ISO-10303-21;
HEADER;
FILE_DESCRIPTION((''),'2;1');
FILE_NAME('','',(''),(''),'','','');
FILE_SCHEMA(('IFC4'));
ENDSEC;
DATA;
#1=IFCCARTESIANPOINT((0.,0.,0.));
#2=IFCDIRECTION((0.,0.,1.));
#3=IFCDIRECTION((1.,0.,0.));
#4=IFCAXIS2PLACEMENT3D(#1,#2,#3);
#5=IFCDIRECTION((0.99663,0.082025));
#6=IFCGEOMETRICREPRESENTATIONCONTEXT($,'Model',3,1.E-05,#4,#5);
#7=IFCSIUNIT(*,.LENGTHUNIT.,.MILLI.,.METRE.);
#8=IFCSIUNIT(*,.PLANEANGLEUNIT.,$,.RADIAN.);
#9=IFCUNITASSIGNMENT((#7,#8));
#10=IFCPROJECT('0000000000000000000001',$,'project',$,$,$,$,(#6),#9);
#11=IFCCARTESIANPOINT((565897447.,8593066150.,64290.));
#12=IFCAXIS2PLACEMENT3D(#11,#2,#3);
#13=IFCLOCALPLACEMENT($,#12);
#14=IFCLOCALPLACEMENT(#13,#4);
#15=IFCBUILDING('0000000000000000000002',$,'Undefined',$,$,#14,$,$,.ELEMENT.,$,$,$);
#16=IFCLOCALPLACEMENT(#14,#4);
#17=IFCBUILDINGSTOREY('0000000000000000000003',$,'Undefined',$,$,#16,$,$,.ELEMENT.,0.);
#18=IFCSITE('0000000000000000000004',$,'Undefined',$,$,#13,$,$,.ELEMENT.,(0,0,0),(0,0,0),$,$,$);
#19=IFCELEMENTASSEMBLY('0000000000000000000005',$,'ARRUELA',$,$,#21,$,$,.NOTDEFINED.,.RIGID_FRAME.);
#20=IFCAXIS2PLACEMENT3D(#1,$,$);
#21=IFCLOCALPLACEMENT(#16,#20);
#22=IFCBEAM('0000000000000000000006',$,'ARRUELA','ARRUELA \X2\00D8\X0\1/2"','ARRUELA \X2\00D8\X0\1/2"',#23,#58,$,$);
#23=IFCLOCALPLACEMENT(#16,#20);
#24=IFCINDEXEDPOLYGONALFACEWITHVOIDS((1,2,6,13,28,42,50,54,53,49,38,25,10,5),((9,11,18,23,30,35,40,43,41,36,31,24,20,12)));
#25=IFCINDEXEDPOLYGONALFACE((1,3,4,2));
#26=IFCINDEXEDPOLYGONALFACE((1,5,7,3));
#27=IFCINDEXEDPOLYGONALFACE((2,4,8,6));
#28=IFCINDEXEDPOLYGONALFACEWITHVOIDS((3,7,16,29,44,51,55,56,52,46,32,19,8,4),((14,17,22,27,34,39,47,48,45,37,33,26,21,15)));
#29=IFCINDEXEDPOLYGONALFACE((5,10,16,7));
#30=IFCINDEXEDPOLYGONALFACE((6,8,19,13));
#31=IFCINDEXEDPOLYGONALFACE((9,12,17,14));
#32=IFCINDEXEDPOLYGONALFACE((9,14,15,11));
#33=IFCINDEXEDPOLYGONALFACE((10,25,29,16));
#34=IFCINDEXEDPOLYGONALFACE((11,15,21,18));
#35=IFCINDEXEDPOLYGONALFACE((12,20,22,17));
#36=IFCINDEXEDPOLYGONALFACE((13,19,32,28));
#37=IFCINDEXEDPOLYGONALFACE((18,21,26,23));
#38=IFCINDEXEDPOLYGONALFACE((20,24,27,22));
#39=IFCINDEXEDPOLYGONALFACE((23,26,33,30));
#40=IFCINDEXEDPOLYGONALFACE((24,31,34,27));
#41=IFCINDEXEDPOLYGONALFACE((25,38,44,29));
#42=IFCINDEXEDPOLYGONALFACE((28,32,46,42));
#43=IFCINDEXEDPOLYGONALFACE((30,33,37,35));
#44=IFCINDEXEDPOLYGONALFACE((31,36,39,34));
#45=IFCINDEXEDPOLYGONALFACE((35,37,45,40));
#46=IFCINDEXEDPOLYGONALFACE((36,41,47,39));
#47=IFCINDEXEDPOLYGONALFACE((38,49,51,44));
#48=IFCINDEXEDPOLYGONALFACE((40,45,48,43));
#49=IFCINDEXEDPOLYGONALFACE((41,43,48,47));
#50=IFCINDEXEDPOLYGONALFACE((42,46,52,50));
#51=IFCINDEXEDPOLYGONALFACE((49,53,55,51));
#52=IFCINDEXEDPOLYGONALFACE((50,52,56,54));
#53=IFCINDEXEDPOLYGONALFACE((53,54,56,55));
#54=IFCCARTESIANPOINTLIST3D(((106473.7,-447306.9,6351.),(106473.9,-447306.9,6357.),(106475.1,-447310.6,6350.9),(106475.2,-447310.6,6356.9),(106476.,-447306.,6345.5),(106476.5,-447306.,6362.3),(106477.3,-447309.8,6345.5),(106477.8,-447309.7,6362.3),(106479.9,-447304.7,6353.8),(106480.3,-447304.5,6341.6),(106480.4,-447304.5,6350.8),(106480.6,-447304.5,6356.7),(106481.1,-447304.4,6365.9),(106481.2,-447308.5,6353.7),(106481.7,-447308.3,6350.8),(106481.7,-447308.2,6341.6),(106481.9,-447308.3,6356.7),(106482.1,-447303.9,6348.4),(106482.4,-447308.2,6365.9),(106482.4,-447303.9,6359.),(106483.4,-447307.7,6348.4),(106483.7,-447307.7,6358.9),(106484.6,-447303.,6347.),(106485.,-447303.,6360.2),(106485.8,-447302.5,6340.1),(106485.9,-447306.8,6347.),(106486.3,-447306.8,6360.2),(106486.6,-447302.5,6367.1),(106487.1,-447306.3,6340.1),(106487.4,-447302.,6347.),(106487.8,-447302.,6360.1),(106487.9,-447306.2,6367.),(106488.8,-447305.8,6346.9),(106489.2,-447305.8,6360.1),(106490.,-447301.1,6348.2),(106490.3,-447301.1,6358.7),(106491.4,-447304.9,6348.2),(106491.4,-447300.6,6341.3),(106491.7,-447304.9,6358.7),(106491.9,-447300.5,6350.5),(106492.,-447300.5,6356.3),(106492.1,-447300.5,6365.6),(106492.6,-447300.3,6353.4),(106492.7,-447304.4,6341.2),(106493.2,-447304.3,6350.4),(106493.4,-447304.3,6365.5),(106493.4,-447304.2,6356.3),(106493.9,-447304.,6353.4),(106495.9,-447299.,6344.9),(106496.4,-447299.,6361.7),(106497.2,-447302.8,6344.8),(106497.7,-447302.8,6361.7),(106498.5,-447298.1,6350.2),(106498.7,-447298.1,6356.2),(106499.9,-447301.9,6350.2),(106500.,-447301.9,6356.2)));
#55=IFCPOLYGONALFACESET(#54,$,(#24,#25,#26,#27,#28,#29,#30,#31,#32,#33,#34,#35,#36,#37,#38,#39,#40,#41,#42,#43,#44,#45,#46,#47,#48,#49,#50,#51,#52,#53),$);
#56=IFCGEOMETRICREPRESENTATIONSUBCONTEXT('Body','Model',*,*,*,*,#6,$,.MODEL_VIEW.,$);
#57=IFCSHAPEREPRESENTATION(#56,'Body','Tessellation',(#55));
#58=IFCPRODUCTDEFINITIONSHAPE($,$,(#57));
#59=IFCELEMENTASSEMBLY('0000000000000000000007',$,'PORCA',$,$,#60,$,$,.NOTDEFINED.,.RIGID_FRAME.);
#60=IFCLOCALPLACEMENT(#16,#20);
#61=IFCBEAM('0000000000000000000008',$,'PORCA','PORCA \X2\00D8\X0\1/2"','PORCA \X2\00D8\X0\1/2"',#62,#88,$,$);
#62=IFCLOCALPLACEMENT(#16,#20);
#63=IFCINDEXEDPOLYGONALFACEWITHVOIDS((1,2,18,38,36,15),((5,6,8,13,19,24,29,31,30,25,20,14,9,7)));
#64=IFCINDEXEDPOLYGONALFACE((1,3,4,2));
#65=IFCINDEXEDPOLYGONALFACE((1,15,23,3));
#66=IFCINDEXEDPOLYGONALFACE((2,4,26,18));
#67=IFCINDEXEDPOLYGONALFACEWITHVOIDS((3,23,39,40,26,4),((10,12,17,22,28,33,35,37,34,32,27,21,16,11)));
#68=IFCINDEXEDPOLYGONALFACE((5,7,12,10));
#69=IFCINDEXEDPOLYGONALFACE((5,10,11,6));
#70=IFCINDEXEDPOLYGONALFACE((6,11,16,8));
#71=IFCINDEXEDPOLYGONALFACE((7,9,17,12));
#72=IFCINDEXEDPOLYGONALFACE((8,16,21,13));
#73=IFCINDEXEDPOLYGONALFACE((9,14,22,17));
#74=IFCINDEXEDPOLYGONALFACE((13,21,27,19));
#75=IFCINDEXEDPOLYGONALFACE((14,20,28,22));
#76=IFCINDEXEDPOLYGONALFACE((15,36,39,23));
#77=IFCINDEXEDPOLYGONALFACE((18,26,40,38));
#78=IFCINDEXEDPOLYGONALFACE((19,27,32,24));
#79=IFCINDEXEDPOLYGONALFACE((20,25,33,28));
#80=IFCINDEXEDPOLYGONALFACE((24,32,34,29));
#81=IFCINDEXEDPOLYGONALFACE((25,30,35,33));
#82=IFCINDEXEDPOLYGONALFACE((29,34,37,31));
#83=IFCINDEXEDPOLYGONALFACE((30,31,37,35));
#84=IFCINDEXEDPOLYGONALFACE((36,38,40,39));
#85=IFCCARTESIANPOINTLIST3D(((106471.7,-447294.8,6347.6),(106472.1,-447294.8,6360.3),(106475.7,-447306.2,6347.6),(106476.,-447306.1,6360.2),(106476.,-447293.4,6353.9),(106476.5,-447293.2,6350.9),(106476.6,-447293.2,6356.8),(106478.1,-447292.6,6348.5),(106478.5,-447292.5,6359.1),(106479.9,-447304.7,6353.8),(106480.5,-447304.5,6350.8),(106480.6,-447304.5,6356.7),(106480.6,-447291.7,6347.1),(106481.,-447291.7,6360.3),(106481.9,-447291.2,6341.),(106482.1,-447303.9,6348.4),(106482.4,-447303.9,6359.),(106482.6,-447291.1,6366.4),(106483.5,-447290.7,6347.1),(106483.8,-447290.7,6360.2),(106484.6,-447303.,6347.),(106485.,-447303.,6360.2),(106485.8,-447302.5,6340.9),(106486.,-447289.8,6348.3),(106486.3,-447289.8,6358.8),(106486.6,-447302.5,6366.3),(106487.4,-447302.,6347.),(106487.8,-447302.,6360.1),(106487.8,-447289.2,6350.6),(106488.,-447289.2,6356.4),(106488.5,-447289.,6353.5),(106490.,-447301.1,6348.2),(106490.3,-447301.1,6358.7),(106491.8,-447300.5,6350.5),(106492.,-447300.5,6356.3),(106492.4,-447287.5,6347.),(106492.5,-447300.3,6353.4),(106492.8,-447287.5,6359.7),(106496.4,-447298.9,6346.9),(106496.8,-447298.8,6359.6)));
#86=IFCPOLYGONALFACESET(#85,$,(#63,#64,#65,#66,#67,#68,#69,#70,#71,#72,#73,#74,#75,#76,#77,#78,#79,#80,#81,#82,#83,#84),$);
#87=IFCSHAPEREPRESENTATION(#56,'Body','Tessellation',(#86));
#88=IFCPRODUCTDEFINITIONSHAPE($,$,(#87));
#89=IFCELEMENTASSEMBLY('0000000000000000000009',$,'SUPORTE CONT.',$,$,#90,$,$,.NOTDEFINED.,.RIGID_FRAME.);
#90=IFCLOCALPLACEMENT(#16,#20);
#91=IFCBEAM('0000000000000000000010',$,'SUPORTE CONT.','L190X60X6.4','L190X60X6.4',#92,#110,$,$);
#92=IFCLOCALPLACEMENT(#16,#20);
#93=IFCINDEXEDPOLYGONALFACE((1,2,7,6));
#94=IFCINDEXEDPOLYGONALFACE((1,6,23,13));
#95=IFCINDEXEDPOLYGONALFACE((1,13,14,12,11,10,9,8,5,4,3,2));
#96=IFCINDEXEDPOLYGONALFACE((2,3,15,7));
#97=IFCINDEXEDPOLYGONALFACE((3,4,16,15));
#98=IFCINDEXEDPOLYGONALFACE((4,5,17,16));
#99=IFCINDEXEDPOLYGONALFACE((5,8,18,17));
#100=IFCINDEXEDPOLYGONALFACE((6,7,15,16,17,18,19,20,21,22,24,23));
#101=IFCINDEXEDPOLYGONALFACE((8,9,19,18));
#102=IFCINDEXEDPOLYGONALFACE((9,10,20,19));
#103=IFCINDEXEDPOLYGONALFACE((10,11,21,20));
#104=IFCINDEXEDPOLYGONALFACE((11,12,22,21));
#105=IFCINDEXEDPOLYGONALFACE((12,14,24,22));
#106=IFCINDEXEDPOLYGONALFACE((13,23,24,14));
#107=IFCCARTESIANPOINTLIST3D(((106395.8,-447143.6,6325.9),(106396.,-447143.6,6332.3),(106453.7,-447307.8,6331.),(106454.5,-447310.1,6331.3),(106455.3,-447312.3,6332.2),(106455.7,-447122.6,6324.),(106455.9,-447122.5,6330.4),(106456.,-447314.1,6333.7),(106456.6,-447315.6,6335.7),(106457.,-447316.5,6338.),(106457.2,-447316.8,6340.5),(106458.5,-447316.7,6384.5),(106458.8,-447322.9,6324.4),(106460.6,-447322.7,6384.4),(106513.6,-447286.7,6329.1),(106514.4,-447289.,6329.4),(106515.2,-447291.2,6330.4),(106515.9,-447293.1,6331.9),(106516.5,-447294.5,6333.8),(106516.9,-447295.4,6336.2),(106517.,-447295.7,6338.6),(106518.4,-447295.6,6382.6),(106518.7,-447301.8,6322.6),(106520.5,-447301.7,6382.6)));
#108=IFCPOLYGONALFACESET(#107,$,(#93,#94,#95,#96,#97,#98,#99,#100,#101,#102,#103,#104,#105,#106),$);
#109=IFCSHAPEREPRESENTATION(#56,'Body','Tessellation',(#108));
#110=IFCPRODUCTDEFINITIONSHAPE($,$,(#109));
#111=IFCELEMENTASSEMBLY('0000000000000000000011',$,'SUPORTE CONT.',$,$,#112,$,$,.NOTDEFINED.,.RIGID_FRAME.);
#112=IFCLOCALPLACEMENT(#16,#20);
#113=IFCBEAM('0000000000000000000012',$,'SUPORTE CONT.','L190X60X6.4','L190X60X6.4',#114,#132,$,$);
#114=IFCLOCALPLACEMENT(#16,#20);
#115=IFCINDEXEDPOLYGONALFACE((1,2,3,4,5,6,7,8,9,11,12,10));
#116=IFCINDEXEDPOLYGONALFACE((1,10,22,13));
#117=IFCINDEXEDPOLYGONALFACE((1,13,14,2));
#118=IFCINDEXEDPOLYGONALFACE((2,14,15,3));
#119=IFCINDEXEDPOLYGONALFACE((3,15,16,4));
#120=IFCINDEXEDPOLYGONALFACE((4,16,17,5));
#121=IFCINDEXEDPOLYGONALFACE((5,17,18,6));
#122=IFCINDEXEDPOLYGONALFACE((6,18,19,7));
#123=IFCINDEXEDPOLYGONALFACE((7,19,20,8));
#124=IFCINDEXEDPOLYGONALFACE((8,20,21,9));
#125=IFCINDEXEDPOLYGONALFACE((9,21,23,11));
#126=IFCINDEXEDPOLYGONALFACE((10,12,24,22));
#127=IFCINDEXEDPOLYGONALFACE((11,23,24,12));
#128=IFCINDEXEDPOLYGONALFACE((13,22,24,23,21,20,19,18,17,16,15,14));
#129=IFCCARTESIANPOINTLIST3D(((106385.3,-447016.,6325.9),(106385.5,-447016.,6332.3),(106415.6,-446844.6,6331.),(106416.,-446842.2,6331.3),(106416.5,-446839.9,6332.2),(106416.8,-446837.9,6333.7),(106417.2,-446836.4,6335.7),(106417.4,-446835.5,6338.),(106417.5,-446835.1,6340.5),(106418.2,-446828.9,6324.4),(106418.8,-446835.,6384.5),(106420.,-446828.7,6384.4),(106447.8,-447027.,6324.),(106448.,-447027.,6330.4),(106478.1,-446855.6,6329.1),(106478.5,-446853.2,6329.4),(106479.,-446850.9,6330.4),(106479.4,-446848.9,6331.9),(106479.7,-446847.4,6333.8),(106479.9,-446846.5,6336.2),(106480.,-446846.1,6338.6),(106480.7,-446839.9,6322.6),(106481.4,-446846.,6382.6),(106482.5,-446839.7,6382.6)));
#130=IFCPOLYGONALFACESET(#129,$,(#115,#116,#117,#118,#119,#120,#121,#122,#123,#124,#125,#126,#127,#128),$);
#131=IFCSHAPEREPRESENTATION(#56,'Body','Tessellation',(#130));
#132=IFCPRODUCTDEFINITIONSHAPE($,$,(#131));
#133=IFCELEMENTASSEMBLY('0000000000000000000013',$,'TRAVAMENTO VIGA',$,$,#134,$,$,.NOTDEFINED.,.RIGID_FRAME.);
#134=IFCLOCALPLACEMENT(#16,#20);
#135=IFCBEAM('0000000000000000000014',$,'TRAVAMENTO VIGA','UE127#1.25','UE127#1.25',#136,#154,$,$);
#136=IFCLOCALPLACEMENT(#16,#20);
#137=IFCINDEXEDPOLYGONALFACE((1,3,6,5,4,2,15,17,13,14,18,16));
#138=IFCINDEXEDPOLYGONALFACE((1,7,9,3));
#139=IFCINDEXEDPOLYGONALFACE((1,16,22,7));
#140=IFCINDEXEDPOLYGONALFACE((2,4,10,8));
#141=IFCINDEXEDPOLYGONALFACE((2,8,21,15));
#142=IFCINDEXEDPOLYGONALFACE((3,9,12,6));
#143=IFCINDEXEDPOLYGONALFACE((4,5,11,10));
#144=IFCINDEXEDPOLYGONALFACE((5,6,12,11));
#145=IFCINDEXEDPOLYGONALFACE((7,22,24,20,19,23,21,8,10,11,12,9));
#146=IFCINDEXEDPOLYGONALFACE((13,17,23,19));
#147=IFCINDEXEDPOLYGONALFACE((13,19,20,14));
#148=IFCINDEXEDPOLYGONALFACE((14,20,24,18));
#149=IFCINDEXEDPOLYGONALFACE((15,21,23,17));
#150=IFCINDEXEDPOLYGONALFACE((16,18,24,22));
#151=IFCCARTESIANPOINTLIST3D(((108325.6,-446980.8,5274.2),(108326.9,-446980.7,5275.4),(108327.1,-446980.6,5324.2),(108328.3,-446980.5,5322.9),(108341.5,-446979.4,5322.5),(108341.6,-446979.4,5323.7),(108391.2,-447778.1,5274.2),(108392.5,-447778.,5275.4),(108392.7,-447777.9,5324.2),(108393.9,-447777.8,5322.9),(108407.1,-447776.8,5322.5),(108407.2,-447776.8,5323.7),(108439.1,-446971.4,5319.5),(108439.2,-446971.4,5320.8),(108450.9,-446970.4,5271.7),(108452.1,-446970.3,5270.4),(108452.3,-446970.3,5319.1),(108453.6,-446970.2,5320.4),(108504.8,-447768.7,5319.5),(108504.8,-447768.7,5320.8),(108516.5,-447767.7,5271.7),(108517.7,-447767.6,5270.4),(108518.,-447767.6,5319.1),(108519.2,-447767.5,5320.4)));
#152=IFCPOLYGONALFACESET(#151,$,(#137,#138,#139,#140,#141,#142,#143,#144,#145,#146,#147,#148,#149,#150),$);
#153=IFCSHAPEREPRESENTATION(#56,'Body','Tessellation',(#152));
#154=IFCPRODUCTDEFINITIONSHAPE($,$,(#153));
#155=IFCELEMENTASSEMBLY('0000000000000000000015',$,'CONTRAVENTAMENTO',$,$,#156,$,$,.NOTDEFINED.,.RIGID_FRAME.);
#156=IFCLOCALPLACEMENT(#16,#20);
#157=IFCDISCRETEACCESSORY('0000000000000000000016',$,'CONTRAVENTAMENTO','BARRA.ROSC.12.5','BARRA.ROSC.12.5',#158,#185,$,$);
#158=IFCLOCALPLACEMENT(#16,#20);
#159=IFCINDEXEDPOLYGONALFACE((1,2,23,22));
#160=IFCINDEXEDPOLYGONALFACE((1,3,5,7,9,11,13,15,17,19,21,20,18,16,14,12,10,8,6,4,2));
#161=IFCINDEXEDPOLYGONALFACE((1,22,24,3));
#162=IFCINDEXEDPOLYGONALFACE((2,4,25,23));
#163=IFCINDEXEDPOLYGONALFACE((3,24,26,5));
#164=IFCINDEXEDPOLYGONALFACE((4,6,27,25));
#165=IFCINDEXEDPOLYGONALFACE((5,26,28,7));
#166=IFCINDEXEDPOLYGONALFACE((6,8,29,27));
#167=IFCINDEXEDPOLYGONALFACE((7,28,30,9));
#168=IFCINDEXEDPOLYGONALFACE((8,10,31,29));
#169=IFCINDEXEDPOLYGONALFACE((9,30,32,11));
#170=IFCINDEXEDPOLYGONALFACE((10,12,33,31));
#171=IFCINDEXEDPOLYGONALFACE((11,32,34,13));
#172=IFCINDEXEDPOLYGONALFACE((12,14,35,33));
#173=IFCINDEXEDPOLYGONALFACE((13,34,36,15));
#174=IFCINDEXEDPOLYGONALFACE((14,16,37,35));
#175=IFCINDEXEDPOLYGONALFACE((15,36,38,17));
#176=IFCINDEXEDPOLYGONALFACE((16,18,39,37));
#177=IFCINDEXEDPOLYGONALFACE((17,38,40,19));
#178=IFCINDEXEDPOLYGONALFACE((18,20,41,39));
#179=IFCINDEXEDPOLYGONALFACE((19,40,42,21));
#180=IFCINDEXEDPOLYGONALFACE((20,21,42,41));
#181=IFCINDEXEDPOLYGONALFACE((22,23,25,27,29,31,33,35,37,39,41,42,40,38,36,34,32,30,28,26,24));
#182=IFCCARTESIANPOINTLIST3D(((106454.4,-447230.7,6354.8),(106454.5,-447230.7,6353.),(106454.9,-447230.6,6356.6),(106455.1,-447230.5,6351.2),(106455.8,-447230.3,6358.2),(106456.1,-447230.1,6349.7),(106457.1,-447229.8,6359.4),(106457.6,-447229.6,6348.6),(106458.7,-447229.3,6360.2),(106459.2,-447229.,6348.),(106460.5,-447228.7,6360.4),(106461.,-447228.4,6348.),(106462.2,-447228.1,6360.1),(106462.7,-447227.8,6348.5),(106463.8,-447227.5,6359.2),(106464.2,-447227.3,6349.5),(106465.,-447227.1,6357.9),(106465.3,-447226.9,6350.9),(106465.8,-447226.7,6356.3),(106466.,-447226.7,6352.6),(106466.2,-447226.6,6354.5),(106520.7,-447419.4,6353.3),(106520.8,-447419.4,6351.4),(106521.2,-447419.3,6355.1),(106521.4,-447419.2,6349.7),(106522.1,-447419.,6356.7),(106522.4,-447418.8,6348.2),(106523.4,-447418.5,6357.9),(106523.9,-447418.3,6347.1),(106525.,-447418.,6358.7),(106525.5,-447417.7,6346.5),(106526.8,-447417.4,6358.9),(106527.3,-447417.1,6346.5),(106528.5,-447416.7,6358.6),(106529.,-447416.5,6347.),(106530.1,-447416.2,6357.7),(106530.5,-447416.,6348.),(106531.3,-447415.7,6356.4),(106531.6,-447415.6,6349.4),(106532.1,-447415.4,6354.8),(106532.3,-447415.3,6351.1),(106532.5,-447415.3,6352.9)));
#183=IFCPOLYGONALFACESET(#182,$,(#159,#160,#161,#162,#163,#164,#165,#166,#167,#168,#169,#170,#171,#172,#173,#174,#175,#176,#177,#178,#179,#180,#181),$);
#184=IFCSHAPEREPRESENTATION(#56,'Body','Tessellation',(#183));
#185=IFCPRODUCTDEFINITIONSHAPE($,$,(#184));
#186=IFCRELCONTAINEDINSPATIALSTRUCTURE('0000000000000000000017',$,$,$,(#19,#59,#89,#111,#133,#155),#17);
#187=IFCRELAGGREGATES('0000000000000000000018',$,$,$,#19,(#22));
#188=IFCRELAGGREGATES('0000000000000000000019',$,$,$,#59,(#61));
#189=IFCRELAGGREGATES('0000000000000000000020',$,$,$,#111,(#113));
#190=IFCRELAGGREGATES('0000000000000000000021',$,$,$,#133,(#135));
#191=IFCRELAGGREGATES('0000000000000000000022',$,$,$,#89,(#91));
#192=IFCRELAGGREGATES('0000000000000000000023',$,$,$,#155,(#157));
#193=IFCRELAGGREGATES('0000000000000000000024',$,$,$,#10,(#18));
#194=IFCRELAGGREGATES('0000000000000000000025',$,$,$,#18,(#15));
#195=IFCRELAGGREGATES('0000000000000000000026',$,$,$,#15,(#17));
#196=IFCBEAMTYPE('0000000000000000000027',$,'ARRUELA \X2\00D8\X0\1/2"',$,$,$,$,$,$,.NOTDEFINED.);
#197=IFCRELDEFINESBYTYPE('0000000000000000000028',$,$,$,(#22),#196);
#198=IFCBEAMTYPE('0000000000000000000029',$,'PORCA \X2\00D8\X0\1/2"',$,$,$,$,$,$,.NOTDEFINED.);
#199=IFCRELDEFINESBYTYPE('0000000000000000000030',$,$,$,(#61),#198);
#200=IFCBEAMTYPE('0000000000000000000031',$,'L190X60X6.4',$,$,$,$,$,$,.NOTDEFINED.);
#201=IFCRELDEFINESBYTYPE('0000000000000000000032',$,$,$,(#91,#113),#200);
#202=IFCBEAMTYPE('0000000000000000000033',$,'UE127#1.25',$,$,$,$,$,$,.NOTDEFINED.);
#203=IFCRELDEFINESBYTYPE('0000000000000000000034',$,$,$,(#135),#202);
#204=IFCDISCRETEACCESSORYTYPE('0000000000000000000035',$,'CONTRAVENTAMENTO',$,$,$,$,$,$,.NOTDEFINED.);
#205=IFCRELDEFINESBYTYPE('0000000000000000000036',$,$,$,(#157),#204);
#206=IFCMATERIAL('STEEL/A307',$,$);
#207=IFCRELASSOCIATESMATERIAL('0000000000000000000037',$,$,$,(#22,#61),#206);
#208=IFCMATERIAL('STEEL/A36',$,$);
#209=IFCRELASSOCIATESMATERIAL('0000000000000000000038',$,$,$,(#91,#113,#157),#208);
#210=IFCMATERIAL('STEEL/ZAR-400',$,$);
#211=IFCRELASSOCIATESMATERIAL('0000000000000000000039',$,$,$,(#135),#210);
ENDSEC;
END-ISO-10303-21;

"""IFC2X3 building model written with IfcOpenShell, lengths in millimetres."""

from ifc_helpers import new_model, si_unit, direction, frame, frame_2d, origin_with_axes, place, context, subcontext, project, spatial, polyline, circle, l_section, c_section, outline, extrude, material, type_object, element, aggregate, save


model = new_model("IFC2X3")

# Units and contexts
model_context = context("Model", 3, precision=1e-05, world=origin_with_axes(), true_north=direction((0.99663, 0.082025)))
body_context = subcontext(model_context, "Body", "Model", "MODEL_VIEW")
ifc_project = project(units=[si_unit("LENGTHUNIT", "METRE", prefix="MILLI"), si_unit("PLANEANGLEUNIT", "RADIAN")], contexts=[model_context])

# Site, building, storey
site_placement = place(None, frame((565897447.0, 8593066150.0, 64290.0), z_axis=(0.0, 0.0, 1.0), x_axis=(1.0, 0.0, 0.0)))
site = spatial("IfcSite", under=ifc_project, at=site_placement, Name="Undefined", CompositionType="ELEMENT", RefLatitude=(0, 0, 0), RefLongitude=(0, 0, 0))
building_placement = place(site_placement, origin_with_axes())
building = spatial("IfcBuilding", under=site, at=building_placement, Name="Undefined", CompositionType="ELEMENT")
storey_placement = place(building_placement, origin_with_axes())
storey = spatial("IfcBuildingStorey", under=building, at=storey_placement, Name="Undefined", CompositionType="ELEMENT", Elevation=0.0)

# Element assemblies, beams
assembly_1_placement = place(storey_placement, origin_with_axes())
assembly_1 = element("IfcElementAssembly", 1, at=assembly_1_placement, inside=storey, Name="ARRUELA", AssemblyPlace="NOTDEFINED", PredefinedType="RIGID_FRAME")
ifc_material_1 = material(Name="STEEL/A307")
beam_type_1 = type_object("IfcBeamType", Name="ARRUELA Ø1/2\"", PredefinedType="NOTDEFINED")
beam_1_placement = place(assembly_1_placement, frame((106486.2, -447302.5, 6353.6), z_axis=(0.942975, 0.331598, -0.02901), x_axis=(0.331521, -0.943417, -0.007591)))
beam_1 = element("IfcBeam", 2, at=beam_1_placement, type_object=beam_type_1, material=ifc_material_1, Name="ARRUELA", Description="ARRUELA Ø1/2\"", ObjectType="ARRUELA Ø1/2\"", context=body_context, shape_type="SweptSolid", body=[
    extrude(outline(polyline([(-8.4, 10.5), (-3.0, 13.2), (3.0, 13.2), (8.4, 10.5), (12.2, 5.9), (13.5, 0.0), (12.2, -5.9), (8.4, -10.5), (3.0, -13.2), (-3.0, -13.2), (-8.4, -10.5), (-12.2, -5.9), (-13.5, 0.0), (-12.2, 5.9), (-8.4, 10.5)]), holes=[polyline([(6.6, 1.5), (5.3, 4.2), (2.9, 6.1), (0.0, 6.7), (-2.9, 6.1), (-5.3, 4.2), (-6.6, 1.5), (-6.6, -1.5), (-5.3, -4.2), (-2.9, -6.1), (0.0, -6.8), (2.9, -6.1), (5.3, -4.2), (6.6, -1.5), (6.6, 1.5)])]), frame((4.0, 0.0, 0.0), z_axis=(-1.0, 0.0, 0.0), x_axis=(0.0, -1.0, 0.0)), (0.0, 0.0, 1.0), 4.0),
])
aggregate(assembly_1, [beam_1])
assembly_2_placement = place(storey_placement, origin_with_axes())
assembly_2 = element("IfcElementAssembly", 3, at=assembly_2_placement, inside=storey, Name="PORCA", AssemblyPlace="NOTDEFINED", PredefinedType="RIGID_FRAME")
beam_type_2 = type_object("IfcBeamType", Name="PORCA Ø1/2\"", PredefinedType="NOTDEFINED")
beam_2_placement = place(assembly_2_placement, frame((106482.2, -447291.2, 6353.7), z_axis=(0.942975, 0.331598, -0.02901), x_axis=(0.331521, -0.943417, -0.007591)))
beam_2 = element("IfcBeam", 4, at=beam_2_placement, type_object=beam_type_2, material=ifc_material_1, Name="PORCA", Description="PORCA Ø1/2\"", ObjectType="PORCA Ø1/2\"", context=body_context, shape_type="SweptSolid", body=[
    extrude(outline(polyline([(12.7, 0.0), (6.3, -11.0), (-6.3, -11.0), (-12.7, 0.0), (-6.3, 11.0), (6.3, 11.0), (12.7, 0.0)]), holes=[polyline([(-5.3, -4.2), (-2.9, -6.0), (0.0, -6.7), (2.9, -6.0), (5.3, -4.2), (6.6, -1.5), (6.6, 1.5), (5.3, 4.2), (2.9, 6.0), (0.0, 6.7), (-2.9, 6.0), (-5.3, 4.2), (-6.6, 1.5), (-6.6, -1.5), (-5.3, -4.2)])]), frame((12.0, 0.0, 0.0), z_axis=(-1.0, 0.0, 0.0), x_axis=(0.0, -1.0, 0.0)), (0.0, 0.0, 1.0), 12.0),
])
aggregate(assembly_2, [beam_2])
assembly_3_placement = place(storey_placement, origin_with_axes())
assembly_3 = element("IfcElementAssembly", 5, at=assembly_3_placement, inside=storey, Name="SUPORTE CONT.", AssemblyPlace="NOTDEFINED", PredefinedType="RIGID_FRAME")
ifc_material_2 = material(Name="STEEL/A36")
beam_type_3 = type_object("IfcBeamType", Name="L190X60X6.4", PredefinedType="NOTDEFINED")
beam_3_placement = place(assembly_3_placement, frame((106428.2, -447233.2, 6355.1), z_axis=(-0.331521, 0.943417, 0.007591), x_axis=(0.942975, 0.331598, -0.02901)))
beam_3 = element("IfcBeam", 6, at=beam_3_placement, type_object=beam_type_3, material=ifc_material_2, Name="SUPORTE CONT.", Description="L190X60X6.4", ObjectType="L190X60X6.4", context=body_context, shape_type="SweptSolid", body=[
    extrude(l_section(Depth=190.0, Width=60.0, Thickness=6.4, FilletRadius=9.6, at=frame_2d((0.0, 0.0), x_axis=(1.0, 0.0))), frame((63.5, 0.0, 0.0), z_axis=(-1.0, 0.0, 0.0), x_axis=(0.0, -1.0, 0.0)), (0.0, 0.0, 1.0), 63.5),
])
assembly_4_placement = place(storey_placement, origin_with_axes())
assembly_4 = element("IfcElementAssembly", 7, at=assembly_4_placement, inside=storey, Name="SUPORTE CONT.", AssemblyPlace="NOTDEFINED", PredefinedType="RIGID_FRAME")
beam_4_placement = place(assembly_4_placement, frame((106465.2, -446933.4, 6353.3), z_axis=(-0.172812, -0.984925, 0.007591), x_axis=(-0.984501, 0.172962, 0.02901)))
beam_4 = element("IfcBeam", 8, at=beam_4_placement, type_object=beam_type_3, material=ifc_material_2, Name="SUPORTE CONT.", Description="L190X60X6.4", ObjectType="L190X60X6.4", context=body_context, shape_type="SweptSolid", body=[
    extrude(l_section(Depth=190.0, Width=60.0, Thickness=6.4, FilletRadius=9.6, at=frame_2d((0.0, 0.0), x_axis=(1.0, 0.0))), frame((63.5, 0.0, 0.0), z_axis=(-1.0, 0.0, 0.0), x_axis=(0.0, -1.0, 0.0)), (0.0, 0.0, 1.0), 63.5),
])
aggregate(assembly_4, [beam_4])
assembly_5_placement = place(storey_placement, origin_with_axes())
assembly_5 = element("IfcElementAssembly", 9, at=assembly_5_placement, inside=storey, Name="TRAVAMENTO VIGA", AssemblyPlace="NOTDEFINED", PredefinedType="RIGID_FRAME")
ifc_material_3 = material(Name="STEEL/ZAR-400")
beam_type_4 = type_object("IfcBeamType", Name="UE127#1.25", PredefinedType="NOTDEFINED")
beam_5_placement = place(assembly_5_placement, frame((108455.2, -447772.8, 5297.3), z_axis=(-0.996182, -0.081989, 0.029987), x_axis=(-0.082025, 0.99663, 0.0)))
beam_5 = element("IfcBeam", 10, at=beam_5_placement, type_object=beam_type_4, material=ifc_material_3, Name="TRAVAMENTO VIGA", Description="UE127#1.25", ObjectType="UE127#1.25", context=body_context, shape_type="SweptSolid", body=[
    extrude(c_section(Depth=127.0, Width=50.0, WallThickness=1.2, Girth=14.5, at=frame_2d((0.0, 0.0), x_axis=(1.0, 0.0))), frame((800.0, 0.0, 0.0), z_axis=(-1.0, 0.0, 0.0), x_axis=(0.0, -1.0, 0.0)), (0.0, 0.0, 1.0), 800.0),
])
aggregate(assembly_5, [beam_5])

aggregate(assembly_3, [beam_3])

# Element assembly, discrete accessory
assembly_6_placement = place(storey_placement, origin_with_axes())
assembly_6 = element("IfcElementAssembly", 11, at=assembly_6_placement, inside=storey, Name="CONTRAVENTAMENTO", AssemblyPlace="NOTDEFINED", PredefinedType="RIGID_FRAME")
discrete_accessory_type_1 = type_object("IfcDiscreteAccessoryType", Name="CONTRAVENTAMENTO")
discrete_accessory_1_placement = place(assembly_6_placement, frame((106460.3, -447228.7, 6354.2), z_axis=(0.942975, 0.331598, -0.02901), x_axis=(0.331521, -0.943417, -0.007591)))
discrete_accessory_1 = element("IfcDiscreteAccessory", 12, at=discrete_accessory_1_placement, type_object=discrete_accessory_type_1, material=ifc_material_2, Name="CONTRAVENTAMENTO", Description="BARRA.ROSC.12.5", ObjectType="BARRA.ROSC.12.5", context=body_context, shape_type="SweptSolid", body=[
    extrude(circle(Radius=6.2, at=frame_2d((0.0, 0.0), x_axis=(1.0, 0.0))), frame((200.0, 0.0, 0.0), z_axis=(-1.0, 0.0, 0.0), x_axis=(0.0, -1.0, 0.0)), (0.0, 0.0, 1.0), 200.0),
])
aggregate(assembly_6, [discrete_accessory_1])

save(model, "model.ifc")
